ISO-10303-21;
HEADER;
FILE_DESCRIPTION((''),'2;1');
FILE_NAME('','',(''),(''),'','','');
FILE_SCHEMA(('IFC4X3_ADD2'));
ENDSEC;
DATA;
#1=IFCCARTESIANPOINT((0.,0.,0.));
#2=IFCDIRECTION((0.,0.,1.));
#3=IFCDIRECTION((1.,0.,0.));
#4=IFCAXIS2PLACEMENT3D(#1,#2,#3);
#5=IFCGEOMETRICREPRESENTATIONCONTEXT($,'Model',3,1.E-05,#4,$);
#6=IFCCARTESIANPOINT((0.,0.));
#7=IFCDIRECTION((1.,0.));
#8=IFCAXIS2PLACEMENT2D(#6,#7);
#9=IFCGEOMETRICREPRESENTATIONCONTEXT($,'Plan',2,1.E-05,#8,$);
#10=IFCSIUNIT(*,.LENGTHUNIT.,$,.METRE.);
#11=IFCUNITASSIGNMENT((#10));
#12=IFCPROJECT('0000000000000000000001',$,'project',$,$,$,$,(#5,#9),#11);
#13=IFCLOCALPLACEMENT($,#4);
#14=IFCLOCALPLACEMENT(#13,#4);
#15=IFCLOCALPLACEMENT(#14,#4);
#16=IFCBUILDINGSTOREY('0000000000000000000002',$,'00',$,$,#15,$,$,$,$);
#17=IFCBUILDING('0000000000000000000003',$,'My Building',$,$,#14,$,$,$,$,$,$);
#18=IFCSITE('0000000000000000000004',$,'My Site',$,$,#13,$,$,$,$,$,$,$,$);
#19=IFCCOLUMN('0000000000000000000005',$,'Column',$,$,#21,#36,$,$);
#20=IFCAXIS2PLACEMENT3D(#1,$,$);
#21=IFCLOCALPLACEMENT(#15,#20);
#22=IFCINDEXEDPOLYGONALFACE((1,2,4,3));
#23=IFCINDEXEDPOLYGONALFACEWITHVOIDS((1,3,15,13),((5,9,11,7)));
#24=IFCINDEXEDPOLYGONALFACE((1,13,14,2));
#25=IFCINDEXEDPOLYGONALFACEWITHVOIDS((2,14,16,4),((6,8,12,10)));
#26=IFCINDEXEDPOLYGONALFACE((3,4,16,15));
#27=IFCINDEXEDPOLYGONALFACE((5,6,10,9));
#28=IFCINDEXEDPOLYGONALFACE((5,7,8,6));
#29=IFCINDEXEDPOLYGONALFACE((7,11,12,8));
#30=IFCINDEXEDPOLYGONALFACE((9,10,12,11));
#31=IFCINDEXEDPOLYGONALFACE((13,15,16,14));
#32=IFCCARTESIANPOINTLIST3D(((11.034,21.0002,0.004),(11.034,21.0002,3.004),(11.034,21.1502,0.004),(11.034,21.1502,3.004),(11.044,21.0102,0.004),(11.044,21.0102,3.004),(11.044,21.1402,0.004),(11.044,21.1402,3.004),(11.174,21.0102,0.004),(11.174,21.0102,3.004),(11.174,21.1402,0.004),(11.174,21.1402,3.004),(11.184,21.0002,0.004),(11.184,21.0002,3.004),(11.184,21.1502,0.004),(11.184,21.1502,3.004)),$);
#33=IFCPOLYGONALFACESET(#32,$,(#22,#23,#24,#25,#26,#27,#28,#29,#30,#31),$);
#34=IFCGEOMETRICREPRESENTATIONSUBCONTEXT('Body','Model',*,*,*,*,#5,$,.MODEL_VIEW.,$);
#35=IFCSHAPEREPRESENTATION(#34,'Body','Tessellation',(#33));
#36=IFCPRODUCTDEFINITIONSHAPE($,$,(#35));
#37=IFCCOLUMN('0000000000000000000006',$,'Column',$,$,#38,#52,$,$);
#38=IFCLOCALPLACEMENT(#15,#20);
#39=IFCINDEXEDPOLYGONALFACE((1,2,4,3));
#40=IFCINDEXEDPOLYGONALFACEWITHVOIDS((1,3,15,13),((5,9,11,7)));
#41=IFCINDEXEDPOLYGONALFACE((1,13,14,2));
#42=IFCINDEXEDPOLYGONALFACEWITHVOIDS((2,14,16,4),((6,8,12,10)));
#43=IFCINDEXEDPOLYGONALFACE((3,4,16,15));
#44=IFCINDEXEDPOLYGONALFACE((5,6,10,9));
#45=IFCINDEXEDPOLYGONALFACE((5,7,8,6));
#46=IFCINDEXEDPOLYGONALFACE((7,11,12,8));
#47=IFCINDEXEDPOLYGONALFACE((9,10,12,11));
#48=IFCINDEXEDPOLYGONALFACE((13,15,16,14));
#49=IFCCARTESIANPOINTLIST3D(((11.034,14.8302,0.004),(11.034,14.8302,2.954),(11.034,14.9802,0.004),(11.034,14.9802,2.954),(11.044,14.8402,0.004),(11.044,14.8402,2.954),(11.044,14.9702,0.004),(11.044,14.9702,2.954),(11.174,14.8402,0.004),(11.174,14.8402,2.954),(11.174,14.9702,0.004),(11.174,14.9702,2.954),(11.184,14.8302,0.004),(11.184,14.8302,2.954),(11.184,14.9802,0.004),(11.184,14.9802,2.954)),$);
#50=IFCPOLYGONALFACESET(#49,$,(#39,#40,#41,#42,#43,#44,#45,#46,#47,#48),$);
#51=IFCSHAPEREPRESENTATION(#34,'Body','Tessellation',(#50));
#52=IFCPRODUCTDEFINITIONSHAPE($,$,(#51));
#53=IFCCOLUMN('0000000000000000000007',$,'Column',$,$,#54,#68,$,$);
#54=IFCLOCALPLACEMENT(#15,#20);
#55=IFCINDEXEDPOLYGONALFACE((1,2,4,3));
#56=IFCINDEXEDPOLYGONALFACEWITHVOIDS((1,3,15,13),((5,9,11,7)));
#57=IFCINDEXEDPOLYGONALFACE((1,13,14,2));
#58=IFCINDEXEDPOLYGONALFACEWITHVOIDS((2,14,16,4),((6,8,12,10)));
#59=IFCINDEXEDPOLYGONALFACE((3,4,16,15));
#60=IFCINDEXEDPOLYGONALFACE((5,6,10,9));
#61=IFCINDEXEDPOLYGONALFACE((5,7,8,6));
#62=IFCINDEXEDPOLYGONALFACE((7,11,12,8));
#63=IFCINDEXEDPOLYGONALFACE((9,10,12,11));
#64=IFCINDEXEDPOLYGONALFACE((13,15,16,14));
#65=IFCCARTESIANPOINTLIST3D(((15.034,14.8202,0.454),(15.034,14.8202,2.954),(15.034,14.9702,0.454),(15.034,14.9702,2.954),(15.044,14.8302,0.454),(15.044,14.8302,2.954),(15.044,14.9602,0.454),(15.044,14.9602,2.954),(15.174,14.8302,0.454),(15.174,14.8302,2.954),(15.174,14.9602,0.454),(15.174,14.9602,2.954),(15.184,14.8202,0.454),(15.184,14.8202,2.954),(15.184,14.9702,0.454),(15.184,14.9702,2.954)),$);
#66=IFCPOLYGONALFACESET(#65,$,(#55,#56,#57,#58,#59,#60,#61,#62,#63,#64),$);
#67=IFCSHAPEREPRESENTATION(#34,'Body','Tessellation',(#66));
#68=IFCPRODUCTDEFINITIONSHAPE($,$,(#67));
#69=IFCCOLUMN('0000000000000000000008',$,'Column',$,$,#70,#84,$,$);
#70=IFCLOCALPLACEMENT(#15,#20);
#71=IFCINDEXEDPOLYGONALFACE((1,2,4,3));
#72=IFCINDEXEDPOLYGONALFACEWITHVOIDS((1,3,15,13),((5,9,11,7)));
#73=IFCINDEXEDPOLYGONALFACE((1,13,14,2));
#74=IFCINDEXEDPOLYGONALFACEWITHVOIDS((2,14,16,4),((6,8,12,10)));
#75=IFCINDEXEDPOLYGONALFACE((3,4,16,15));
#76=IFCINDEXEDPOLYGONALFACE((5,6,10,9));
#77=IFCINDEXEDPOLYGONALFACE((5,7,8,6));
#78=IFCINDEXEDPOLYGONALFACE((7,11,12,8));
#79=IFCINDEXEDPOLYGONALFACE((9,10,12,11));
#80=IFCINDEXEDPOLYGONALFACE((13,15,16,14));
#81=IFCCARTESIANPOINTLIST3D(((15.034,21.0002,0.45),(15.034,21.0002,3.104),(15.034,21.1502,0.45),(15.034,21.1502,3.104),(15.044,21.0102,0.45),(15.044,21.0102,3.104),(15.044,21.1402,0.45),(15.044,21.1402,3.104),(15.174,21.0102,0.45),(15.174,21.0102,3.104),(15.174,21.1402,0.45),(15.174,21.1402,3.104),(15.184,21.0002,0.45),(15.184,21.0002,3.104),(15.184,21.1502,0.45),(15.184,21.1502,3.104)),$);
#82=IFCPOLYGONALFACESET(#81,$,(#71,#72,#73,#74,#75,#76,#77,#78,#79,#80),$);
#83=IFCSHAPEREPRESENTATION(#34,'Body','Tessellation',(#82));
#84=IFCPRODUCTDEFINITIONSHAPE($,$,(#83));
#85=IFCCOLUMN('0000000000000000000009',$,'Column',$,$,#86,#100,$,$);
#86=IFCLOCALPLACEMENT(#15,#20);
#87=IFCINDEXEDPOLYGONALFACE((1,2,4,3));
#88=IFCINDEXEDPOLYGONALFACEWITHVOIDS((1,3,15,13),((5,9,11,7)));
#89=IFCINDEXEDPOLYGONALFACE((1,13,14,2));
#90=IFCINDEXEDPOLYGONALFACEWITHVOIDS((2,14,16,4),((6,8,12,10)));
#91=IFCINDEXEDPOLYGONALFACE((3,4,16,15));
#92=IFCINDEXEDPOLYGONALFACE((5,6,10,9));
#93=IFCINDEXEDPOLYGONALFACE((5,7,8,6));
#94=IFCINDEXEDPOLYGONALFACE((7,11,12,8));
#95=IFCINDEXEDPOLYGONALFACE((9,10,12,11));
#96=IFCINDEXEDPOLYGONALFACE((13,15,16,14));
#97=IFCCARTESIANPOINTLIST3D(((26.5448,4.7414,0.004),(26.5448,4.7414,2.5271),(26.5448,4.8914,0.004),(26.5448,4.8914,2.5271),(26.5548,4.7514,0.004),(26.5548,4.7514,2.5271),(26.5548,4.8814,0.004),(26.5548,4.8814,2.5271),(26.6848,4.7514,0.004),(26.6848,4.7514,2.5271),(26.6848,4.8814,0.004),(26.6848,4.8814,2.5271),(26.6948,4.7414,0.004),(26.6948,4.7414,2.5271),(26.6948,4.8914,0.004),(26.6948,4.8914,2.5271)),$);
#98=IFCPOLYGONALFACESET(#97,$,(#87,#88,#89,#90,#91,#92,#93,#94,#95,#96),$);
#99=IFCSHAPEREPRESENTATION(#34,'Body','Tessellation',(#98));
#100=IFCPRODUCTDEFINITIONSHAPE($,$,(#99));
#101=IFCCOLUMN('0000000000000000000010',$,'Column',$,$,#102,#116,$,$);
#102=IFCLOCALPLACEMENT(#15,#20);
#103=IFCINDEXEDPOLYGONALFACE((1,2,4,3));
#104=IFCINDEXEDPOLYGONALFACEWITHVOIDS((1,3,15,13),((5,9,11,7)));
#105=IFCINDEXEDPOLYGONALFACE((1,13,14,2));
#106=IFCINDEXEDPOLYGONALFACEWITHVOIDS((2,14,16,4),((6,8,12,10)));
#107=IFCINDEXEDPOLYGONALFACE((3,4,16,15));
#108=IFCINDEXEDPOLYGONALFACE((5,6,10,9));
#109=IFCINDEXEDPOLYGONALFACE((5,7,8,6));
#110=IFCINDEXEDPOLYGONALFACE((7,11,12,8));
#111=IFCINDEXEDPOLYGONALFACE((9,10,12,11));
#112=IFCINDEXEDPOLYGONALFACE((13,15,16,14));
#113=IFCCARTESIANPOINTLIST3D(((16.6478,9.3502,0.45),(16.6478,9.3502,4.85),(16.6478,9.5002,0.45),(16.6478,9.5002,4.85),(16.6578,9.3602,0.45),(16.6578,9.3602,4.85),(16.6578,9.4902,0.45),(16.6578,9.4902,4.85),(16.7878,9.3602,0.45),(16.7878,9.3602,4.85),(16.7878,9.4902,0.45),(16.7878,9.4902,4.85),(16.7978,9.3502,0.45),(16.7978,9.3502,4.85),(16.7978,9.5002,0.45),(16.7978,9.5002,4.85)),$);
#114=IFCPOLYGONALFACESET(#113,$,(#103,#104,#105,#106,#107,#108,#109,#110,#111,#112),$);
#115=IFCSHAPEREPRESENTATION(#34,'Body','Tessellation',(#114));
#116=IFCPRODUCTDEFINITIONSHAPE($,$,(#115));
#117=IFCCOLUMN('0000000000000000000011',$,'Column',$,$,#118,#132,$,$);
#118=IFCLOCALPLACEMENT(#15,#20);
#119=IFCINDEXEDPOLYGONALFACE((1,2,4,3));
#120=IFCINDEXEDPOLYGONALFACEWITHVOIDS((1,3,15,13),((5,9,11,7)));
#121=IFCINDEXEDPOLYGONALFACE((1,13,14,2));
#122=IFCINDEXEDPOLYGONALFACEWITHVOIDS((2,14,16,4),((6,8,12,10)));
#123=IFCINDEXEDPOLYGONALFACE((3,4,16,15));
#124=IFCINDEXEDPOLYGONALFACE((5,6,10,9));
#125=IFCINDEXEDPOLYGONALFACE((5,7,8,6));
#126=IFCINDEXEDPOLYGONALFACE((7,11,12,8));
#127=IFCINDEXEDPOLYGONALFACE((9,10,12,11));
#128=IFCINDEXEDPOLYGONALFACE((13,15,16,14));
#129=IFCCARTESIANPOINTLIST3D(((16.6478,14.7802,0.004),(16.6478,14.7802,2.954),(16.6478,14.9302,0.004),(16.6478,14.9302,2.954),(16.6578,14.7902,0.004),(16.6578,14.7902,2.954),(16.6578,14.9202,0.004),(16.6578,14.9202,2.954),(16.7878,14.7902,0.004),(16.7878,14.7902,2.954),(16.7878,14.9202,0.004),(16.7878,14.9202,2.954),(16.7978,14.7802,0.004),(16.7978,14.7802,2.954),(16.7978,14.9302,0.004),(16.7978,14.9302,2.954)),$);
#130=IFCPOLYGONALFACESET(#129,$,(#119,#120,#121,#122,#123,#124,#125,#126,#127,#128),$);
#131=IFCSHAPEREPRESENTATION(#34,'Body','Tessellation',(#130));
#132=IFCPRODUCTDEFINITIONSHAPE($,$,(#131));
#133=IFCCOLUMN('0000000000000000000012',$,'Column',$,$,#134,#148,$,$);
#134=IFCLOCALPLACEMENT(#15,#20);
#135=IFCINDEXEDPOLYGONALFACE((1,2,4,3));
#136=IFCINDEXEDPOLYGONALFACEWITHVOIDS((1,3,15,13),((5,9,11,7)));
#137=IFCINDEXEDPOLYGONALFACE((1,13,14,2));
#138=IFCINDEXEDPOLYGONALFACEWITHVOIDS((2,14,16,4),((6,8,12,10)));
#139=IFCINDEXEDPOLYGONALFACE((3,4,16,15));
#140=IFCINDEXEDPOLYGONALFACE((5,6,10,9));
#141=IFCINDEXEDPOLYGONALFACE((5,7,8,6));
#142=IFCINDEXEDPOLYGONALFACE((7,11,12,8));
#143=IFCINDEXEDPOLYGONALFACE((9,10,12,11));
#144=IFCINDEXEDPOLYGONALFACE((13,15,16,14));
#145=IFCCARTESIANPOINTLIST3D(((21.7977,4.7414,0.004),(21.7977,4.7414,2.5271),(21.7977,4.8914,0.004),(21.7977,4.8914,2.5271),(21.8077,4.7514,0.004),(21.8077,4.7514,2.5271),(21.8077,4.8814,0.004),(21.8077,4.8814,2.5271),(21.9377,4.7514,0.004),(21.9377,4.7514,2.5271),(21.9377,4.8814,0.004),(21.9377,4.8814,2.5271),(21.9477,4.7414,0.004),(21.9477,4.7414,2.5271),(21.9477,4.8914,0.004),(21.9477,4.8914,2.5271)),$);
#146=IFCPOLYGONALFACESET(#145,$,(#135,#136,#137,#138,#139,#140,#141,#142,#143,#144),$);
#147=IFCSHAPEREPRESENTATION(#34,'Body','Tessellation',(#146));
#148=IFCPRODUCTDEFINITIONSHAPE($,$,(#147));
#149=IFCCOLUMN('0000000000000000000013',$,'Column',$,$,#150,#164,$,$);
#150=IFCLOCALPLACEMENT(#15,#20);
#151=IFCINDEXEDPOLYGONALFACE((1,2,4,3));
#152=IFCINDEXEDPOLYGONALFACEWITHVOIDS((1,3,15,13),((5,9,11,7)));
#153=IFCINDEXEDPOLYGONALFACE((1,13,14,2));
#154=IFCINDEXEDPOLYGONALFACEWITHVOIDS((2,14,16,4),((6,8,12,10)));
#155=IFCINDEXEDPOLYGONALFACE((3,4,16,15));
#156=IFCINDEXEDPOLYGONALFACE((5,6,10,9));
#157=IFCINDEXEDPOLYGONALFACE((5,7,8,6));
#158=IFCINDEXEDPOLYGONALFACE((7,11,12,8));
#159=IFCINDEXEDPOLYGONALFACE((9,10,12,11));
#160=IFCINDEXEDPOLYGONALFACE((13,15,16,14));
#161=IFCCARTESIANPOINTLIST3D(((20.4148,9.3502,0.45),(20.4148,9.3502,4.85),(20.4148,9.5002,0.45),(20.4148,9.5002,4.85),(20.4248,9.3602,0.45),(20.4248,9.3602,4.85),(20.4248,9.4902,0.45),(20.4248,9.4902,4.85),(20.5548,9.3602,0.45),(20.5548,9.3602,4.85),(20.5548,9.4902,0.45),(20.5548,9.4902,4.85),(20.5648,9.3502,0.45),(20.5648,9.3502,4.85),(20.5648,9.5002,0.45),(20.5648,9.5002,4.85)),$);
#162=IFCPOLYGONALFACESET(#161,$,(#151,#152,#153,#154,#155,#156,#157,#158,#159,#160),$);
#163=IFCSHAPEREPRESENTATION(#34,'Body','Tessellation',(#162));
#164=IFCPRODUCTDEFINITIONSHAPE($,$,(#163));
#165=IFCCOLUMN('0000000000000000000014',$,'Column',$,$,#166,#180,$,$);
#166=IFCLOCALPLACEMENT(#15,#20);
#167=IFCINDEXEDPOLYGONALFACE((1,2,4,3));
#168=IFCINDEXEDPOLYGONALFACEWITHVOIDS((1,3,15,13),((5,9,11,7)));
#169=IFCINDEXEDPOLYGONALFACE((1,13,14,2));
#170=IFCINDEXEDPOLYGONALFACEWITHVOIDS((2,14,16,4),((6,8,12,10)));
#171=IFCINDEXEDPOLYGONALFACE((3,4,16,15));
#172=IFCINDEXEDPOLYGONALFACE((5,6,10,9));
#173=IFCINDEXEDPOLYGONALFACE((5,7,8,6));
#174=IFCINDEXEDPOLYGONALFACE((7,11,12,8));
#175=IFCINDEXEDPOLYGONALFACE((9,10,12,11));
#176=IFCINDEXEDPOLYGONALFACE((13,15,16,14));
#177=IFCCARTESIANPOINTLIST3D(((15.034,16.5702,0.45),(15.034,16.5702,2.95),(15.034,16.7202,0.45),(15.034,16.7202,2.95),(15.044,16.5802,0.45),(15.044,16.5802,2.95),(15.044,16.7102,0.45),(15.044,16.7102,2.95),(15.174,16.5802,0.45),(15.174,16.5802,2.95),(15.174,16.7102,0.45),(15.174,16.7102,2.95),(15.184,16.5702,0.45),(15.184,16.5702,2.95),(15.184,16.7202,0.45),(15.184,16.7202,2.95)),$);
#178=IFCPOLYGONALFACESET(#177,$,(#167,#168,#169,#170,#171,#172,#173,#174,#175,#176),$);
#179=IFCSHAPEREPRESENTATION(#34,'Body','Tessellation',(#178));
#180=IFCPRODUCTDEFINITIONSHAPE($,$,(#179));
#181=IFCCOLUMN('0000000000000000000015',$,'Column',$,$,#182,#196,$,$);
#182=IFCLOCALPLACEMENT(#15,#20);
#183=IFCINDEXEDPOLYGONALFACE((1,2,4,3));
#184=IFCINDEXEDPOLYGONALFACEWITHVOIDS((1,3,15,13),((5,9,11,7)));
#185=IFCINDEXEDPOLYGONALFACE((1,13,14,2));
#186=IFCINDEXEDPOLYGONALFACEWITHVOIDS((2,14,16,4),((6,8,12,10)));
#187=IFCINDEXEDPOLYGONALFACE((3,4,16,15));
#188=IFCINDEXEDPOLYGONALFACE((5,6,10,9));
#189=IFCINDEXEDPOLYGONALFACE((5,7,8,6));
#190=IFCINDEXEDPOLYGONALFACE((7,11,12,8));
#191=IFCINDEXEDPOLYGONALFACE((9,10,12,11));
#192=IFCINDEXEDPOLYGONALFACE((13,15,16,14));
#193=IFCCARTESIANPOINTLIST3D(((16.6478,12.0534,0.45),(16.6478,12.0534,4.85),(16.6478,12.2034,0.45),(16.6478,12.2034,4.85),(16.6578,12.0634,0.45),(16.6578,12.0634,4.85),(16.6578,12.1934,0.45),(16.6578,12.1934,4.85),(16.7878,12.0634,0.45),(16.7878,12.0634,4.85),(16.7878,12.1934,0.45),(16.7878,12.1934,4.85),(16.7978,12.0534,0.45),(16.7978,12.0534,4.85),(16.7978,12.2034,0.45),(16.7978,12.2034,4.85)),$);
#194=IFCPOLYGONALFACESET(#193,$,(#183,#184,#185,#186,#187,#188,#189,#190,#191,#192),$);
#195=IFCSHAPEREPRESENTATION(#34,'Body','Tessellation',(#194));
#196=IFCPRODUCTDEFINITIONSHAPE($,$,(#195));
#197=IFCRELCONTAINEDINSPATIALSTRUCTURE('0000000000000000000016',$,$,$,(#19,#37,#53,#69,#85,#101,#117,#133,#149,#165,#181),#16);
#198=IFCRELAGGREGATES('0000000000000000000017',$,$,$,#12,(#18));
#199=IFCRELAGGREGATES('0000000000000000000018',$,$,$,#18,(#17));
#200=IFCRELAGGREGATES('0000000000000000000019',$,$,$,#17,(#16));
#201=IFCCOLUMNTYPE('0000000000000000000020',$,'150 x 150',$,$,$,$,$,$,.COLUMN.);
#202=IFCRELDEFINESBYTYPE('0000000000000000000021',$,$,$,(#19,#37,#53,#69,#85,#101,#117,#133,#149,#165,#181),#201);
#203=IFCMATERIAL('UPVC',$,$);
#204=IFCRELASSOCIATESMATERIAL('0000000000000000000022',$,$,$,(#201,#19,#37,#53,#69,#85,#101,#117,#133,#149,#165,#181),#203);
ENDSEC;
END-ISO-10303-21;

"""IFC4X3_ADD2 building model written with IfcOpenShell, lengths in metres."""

from ifc_helpers import new_model, si_unit, frame, origin_with_axes, origin_2d_with_axis, place, context, subcontext, project, spatial, hollow_rectangle, extrude, material, material_profile, profile_set, profile_usage, type_object, element, save


model = new_model("IFC4X3_ADD2")

# Units and contexts
model_context = context("Model", 3, precision=1e-05, world=origin_with_axes())
plan_context = context("Plan", 2, precision=1e-05, world=origin_2d_with_axis())
body_context = subcontext(model_context, "Body", "Model", "MODEL_VIEW")
ifc_project = project(units=[si_unit("LENGTHUNIT", "METRE")], contexts=[model_context, plan_context])

# Site, building, storey
site_placement = place(None, origin_with_axes())
site = spatial("IfcSite", under=ifc_project, at=site_placement, Name="My Site")
building_placement = place(site_placement, origin_with_axes())
building = spatial("IfcBuilding", under=site, at=building_placement, Name="My Building")
storey_placement = place(building_placement, origin_with_axes())
storey = spatial("IfcBuildingStorey", under=building, at=storey_placement, Name="00")

# Columns
ifc_material_1 = material(Name="UPVC")
ifc_material_profile = material_profile(ifc_material_1, hollow_rectangle(XDim=0.15, YDim=0.15, WallThickness=0.01))
ifc_profile_set = profile_set([ifc_material_profile])
ifc_profile_usage_1 = profile_usage(ifc_profile_set)
column_type = type_object("IfcColumnType", Name="150 x 150", PredefinedType="COLUMN", material=ifc_profile_set)
column_1_placement = place(storey_placement, frame((11.109, 21.0752, 0.004), z_axis=(0.0, 0.0, 1.0), x_axis=(1.0, 0.0, 0.0)))
element("IfcColumn", 1, at=column_1_placement, inside=storey, type_object=column_type, material=ifc_profile_usage_1, Name="Column", context=body_context, shape_type="SweptSolid", body=[
    extrude(hollow_rectangle(XDim=0.15, YDim=0.15, WallThickness=0.01), origin_with_axes(), (0.0, 0.0, 1.0), 3.0),
])
ifc_profile_usage_2 = profile_usage(ifc_profile_set)
column_2_placement = place(storey_placement, frame((11.109, 14.9052, 0.004), z_axis=(0.0, 0.0, 1.0), x_axis=(1.0, 0.0, 0.0)))
element("IfcColumn", 2, at=column_2_placement, inside=storey, type_object=column_type, material=ifc_profile_usage_2, Name="Column", context=body_context, shape_type="SweptSolid", body=[
    extrude(hollow_rectangle(XDim=0.15, YDim=0.15, WallThickness=0.01), origin_with_axes(), (0.0, 0.0, 1.0), 2.95),
])
ifc_profile_usage_3 = profile_usage(ifc_profile_set)
column_3_placement = place(storey_placement, frame((15.109, 14.8952, 0.454), z_axis=(0.0, 0.0, 1.0), x_axis=(1.0, 0.0, 0.0)))
element("IfcColumn", 3, at=column_3_placement, inside=storey, type_object=column_type, material=ifc_profile_usage_3, Name="Column", context=body_context, shape_type="SweptSolid", body=[
    extrude(hollow_rectangle(XDim=0.15, YDim=0.15, WallThickness=0.01), origin_with_axes(), (0.0, 0.0, 1.0), 2.5),
])
ifc_profile_usage_4 = profile_usage(ifc_profile_set)
column_4_placement = place(storey_placement, frame((15.109, 21.0752, 0.45), z_axis=(0.0, 0.0, 1.0), x_axis=(1.0, 0.0, 0.0)))
element("IfcColumn", 4, at=column_4_placement, inside=storey, type_object=column_type, material=ifc_profile_usage_4, Name="Column", context=body_context, shape_type="SweptSolid", body=[
    extrude(hollow_rectangle(XDim=0.15, YDim=0.15, WallThickness=0.01), origin_with_axes(), (0.0, 0.0, 1.0), 2.654),
])
ifc_profile_usage_5 = profile_usage(ifc_profile_set, cardinal=5)
column_5_placement = place(storey_placement, frame((26.6198, 4.8164, 0.004), z_axis=(0.0, 0.0, 1.0), x_axis=(1.0, 0.0, 0.0)))
element("IfcColumn", 5, at=column_5_placement, inside=storey, type_object=column_type, material=ifc_profile_usage_5, Name="Column", context=body_context, shape_type="SweptSolid", body=[
    extrude(hollow_rectangle(XDim=0.15, YDim=0.15, WallThickness=0.01), origin_with_axes(), (0.0, 0.0, 1.0), 2.5231),
])
ifc_profile_usage_6 = profile_usage(ifc_profile_set, cardinal=5)
column_6_placement = place(storey_placement, frame((16.7228, 9.4252, 0.45), z_axis=(0.0, 0.0, 1.0), x_axis=(1.0, 0.0, 0.0)))
element("IfcColumn", 6, at=column_6_placement, inside=storey, type_object=column_type, material=ifc_profile_usage_6, Name="Column", context=body_context, shape_type="SweptSolid", body=[
    extrude(hollow_rectangle(XDim=0.15, YDim=0.15, WallThickness=0.01), origin_with_axes(), (0.0, 0.0, 1.0), 4.4),
])
ifc_profile_usage_7 = profile_usage(ifc_profile_set, cardinal=5)
column_7_placement = place(storey_placement, frame((16.7228, 14.8552, 0.004), z_axis=(0.0, 0.0, 1.0), x_axis=(1.0, 0.0, 0.0)))
element("IfcColumn", 7, at=column_7_placement, inside=storey, type_object=column_type, material=ifc_profile_usage_7, Name="Column", context=body_context, shape_type="SweptSolid", body=[
    extrude(hollow_rectangle(XDim=0.15, YDim=0.15, WallThickness=0.01), origin_with_axes(), (0.0, 0.0, 1.0), 2.95),
])
ifc_profile_usage_8 = profile_usage(ifc_profile_set, cardinal=5)
column_8_placement = place(storey_placement, frame((21.8727, 4.8164, 0.004), z_axis=(0.0, 0.0, 1.0), x_axis=(1.0, 0.0, 0.0)))
element("IfcColumn", 8, at=column_8_placement, inside=storey, type_object=column_type, material=ifc_profile_usage_8, Name="Column", context=body_context, shape_type="SweptSolid", body=[
    extrude(hollow_rectangle(XDim=0.15, YDim=0.15, WallThickness=0.01), origin_with_axes(), (0.0, 0.0, 1.0), 2.5231),
])
ifc_profile_usage_9 = profile_usage(ifc_profile_set, cardinal=5)
column_9_placement = place(storey_placement, frame((20.4898, 9.4252, 0.45), z_axis=(0.0, 0.0, 1.0), x_axis=(1.0, 0.0, 0.0)))
element("IfcColumn", 9, at=column_9_placement, inside=storey, type_object=column_type, material=ifc_profile_usage_9, Name="Column", context=body_context, shape_type="SweptSolid", body=[
    extrude(hollow_rectangle(XDim=0.15, YDim=0.15, WallThickness=0.01), origin_with_axes(), (0.0, 0.0, 1.0), 4.4),
])
ifc_profile_usage_10 = profile_usage(ifc_profile_set)
column_10_placement = place(storey_placement, frame((15.109, 16.6452, 0.45), z_axis=(0.0, 0.0, 1.0), x_axis=(1.0, 0.0, 0.0)))
element("IfcColumn", 10, at=column_10_placement, inside=storey, type_object=column_type, material=ifc_profile_usage_10, Name="Column", context=body_context, shape_type="SweptSolid", body=[
    extrude(hollow_rectangle(XDim=0.15, YDim=0.15, WallThickness=0.01), origin_with_axes(), (0.0, 0.0, 1.0), 2.5),
])
ifc_profile_usage_11 = profile_usage(ifc_profile_set, cardinal=5)
column_11_placement = place(storey_placement, frame((16.7228, 12.1284, 0.45), z_axis=(0.0, 0.0, 1.0), x_axis=(1.0, 0.0, 0.0)))
element("IfcColumn", 11, at=column_11_placement, inside=storey, type_object=column_type, material=ifc_profile_usage_11, Name="Column", context=body_context, shape_type="SweptSolid", body=[
    extrude(hollow_rectangle(XDim=0.15, YDim=0.15, WallThickness=0.01), origin_with_axes(), (0.0, 0.0, 1.0), 4.4),
])

save(model, "model.ifc")
